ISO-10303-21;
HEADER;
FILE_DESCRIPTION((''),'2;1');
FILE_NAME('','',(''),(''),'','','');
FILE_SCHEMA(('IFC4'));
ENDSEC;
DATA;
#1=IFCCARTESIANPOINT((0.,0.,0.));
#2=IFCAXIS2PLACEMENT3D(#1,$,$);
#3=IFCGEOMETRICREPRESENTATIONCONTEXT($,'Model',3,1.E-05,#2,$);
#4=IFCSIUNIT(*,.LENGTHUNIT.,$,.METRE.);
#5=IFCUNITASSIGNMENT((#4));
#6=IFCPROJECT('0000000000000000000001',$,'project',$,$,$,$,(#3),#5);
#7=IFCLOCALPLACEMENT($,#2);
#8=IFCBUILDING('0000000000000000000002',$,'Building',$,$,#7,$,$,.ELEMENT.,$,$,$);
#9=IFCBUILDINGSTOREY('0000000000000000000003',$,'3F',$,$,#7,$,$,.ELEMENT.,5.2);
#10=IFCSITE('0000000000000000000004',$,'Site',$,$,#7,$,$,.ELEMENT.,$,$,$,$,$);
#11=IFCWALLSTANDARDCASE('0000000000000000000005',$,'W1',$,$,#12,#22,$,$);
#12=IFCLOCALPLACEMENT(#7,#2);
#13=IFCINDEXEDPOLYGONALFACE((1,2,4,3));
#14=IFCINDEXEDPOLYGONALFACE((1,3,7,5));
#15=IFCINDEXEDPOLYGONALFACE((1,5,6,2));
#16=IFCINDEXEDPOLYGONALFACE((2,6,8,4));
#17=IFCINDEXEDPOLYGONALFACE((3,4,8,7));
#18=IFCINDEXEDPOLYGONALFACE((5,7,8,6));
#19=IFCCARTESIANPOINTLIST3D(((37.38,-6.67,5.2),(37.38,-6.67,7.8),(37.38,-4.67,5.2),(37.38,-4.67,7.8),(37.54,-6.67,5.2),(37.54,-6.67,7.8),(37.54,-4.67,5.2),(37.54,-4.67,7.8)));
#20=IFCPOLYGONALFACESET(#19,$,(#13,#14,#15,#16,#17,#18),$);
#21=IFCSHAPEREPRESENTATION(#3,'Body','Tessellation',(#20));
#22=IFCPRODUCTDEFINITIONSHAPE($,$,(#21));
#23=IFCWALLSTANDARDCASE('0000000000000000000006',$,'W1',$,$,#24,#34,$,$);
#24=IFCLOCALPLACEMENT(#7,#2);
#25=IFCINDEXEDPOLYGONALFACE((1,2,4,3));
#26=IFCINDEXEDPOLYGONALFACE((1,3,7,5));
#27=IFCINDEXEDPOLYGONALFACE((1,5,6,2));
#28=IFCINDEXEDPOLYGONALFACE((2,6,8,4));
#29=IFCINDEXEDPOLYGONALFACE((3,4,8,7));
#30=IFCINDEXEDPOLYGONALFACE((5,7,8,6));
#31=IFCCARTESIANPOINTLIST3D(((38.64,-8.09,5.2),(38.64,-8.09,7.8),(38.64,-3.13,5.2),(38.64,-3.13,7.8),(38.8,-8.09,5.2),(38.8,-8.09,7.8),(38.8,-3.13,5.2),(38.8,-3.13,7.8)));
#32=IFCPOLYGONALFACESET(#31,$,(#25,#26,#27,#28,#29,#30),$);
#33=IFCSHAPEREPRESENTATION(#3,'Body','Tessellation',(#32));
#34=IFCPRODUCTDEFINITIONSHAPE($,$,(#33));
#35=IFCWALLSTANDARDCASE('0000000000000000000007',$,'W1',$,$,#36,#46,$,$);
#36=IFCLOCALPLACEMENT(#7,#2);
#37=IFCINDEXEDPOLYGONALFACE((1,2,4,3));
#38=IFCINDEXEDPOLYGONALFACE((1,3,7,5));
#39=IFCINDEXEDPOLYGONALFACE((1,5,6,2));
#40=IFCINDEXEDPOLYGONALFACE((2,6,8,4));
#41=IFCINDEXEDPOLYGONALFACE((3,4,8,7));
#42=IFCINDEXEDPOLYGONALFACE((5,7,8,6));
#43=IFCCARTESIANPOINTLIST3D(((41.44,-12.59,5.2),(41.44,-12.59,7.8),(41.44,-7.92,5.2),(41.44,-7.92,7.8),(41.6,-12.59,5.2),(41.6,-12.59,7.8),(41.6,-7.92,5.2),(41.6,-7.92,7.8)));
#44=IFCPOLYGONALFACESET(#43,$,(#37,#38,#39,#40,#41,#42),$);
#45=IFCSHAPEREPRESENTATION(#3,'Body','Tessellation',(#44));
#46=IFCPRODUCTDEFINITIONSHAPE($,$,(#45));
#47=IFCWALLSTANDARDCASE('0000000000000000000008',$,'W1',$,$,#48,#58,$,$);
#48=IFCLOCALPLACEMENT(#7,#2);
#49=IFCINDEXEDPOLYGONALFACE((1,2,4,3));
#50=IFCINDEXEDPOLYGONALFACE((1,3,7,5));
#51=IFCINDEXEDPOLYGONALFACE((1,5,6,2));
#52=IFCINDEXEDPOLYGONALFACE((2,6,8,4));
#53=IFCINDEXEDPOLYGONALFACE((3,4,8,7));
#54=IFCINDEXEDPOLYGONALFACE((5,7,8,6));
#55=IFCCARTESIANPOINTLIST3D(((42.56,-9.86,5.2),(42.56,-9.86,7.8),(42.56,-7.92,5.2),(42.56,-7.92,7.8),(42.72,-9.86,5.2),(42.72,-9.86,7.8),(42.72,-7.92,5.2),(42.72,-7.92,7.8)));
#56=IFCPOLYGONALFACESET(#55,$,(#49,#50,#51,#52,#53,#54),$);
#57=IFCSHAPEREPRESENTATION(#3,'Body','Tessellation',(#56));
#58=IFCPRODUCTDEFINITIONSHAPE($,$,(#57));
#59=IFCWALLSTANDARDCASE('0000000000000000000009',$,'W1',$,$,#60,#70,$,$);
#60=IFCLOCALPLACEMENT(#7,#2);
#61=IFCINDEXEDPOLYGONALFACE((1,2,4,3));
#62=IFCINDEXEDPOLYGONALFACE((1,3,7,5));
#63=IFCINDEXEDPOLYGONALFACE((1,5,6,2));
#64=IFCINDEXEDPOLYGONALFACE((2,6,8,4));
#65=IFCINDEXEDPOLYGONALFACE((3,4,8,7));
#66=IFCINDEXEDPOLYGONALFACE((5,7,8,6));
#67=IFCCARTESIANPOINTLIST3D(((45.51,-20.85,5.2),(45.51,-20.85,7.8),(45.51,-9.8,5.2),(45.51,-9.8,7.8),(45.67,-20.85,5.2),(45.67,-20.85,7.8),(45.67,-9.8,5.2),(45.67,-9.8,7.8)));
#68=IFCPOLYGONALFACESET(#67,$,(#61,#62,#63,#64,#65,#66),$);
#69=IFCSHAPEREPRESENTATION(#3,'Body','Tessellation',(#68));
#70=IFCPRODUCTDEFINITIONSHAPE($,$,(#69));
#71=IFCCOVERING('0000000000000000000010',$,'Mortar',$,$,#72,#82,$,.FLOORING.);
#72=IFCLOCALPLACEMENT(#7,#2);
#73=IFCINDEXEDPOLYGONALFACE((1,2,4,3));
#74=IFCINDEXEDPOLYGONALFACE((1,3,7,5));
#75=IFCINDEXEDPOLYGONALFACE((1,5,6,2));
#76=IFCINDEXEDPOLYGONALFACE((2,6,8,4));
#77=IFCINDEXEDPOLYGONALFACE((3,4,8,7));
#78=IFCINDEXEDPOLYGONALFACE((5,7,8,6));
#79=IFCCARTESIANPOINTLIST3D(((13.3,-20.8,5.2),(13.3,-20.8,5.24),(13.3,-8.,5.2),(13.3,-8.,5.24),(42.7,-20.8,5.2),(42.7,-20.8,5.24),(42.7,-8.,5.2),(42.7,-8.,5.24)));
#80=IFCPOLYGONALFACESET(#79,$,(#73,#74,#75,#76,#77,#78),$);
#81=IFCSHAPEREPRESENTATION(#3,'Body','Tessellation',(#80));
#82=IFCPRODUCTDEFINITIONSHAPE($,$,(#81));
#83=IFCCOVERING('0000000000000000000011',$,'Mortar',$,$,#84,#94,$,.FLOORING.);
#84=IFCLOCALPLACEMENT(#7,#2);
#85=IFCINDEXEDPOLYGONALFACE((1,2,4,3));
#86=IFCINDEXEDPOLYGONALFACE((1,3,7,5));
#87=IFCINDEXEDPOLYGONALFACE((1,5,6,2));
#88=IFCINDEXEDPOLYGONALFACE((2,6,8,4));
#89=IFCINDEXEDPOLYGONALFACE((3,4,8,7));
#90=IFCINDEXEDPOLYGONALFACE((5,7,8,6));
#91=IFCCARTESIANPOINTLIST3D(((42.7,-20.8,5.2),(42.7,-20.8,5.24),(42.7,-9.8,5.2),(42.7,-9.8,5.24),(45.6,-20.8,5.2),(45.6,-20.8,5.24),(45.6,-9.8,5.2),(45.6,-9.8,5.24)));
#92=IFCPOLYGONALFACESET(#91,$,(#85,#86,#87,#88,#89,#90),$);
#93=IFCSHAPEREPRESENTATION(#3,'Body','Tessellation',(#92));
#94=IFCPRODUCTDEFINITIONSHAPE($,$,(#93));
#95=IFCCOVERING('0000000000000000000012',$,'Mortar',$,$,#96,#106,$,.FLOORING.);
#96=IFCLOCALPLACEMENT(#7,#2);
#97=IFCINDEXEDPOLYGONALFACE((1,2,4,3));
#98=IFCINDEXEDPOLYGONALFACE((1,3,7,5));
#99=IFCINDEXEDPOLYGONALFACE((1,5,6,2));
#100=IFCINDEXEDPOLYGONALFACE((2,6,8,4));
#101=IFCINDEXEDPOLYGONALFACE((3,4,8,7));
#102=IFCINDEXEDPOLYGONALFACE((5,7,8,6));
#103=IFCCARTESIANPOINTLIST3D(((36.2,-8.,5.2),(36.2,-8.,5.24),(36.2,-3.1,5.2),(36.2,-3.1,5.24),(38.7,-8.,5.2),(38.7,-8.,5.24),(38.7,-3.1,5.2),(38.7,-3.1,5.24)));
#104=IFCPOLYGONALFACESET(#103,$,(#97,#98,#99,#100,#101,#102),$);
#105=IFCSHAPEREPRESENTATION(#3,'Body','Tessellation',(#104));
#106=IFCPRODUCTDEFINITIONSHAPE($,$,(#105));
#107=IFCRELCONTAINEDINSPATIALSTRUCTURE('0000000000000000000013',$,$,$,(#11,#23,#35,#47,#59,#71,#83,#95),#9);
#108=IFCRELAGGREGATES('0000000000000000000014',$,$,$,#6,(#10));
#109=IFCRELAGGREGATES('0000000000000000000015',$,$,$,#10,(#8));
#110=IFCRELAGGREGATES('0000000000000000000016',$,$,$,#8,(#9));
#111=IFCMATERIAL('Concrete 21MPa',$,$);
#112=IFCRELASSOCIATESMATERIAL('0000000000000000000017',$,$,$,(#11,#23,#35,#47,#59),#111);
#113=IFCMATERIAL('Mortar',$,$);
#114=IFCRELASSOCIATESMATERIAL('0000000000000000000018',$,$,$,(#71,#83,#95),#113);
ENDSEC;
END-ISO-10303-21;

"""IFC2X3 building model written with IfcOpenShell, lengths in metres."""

from ifc_helpers import new_model, si_unit, frame, origin, origin_2d, place, context, project, spatial, rectangle, extrude, material, element, save


model = new_model("IFC2X3")

# Units and contexts
model_context = context("Model", 3, precision=1e-05, world=origin())
ifc_project = project(units=[si_unit("LENGTHUNIT", "METRE")], contexts=[model_context])

# Site, building, storey
placement = place(None, origin())
site = spatial("IfcSite", under=ifc_project, at=placement, Name="Site", CompositionType="ELEMENT")
building = spatial("IfcBuilding", under=site, at=placement, Name="Building", CompositionType="ELEMENT")
storey = spatial("IfcBuildingStorey", under=building, at=placement, Name="3F", CompositionType="ELEMENT", Elevation=5.2)

# Shared definitions
ifc_material_1 = material(Name="Concrete 21MPa")

# Walls
wall_1_placement = place(None, frame((37.46, -5.67, 5.2)))
element("IfcWallStandardCase", 1, at=wall_1_placement, inside=storey, material=ifc_material_1, Name="W1", context=model_context, shape_type="SweptSolid", body=[
    extrude(rectangle(XDim=0.16, YDim=2.0, at=origin_2d()), origin(), (0.0, 0.0, 1.0), 2.6),
])
wall_2_placement = place(None, frame((38.72, -5.61, 5.2)))
element("IfcWallStandardCase", 2, at=wall_2_placement, inside=storey, material=ifc_material_1, Name="W1", context=model_context, shape_type="SweptSolid", body=[
    extrude(rectangle(XDim=0.16, YDim=4.96, at=origin_2d()), origin(), (0.0, 0.0, 1.0), 2.6),
])
wall_3_placement = place(None, frame((41.52, -10.255, 5.2)))
element("IfcWallStandardCase", 3, at=wall_3_placement, inside=storey, material=ifc_material_1, Name="W1", context=model_context, shape_type="SweptSolid", body=[
    extrude(rectangle(XDim=0.16, YDim=4.67, at=origin_2d()), origin(), (0.0, 0.0, 1.0), 2.6),
])
wall_4_placement = place(None, frame((42.64, -8.89, 5.2)))
element("IfcWallStandardCase", 4, at=wall_4_placement, inside=storey, material=ifc_material_1, Name="W1", context=model_context, shape_type="SweptSolid", body=[
    extrude(rectangle(XDim=0.16, YDim=1.94, at=origin_2d()), origin(), (0.0, 0.0, 1.0), 2.6),
])
wall_5_placement = place(None, frame((45.59, -15.325, 5.2)))
element("IfcWallStandardCase", 5, at=wall_5_placement, inside=storey, material=ifc_material_1, Name="W1", context=model_context, shape_type="SweptSolid", body=[
    extrude(rectangle(XDim=0.16, YDim=11.05, at=origin_2d()), origin(), (0.0, 0.0, 1.0), 2.6),
])

# Coverings
ifc_material_2 = material(Name="Mortar")
covering_1_placement = place(None, frame((28.0, -14.4, 5.2)))
element("IfcCovering", 6, at=covering_1_placement, inside=storey, material=ifc_material_2, Name="Mortar", PredefinedType="FLOORING", context=model_context, shape_type="SweptSolid", body=[
    extrude(rectangle(XDim=29.4, YDim=12.8, at=origin_2d()), origin(), (0.0, 0.0, 1.0), 0.04),
])
covering_2_placement = place(None, frame((44.15, -15.3, 5.2)))
element("IfcCovering", 7, at=covering_2_placement, inside=storey, material=ifc_material_2, Name="Mortar", PredefinedType="FLOORING", context=model_context, shape_type="SweptSolid", body=[
    extrude(rectangle(XDim=2.9, YDim=11.0, at=origin_2d()), origin(), (0.0, 0.0, 1.0), 0.04),
])
covering_3_placement = place(None, frame((37.45, -5.55, 5.2)))
element("IfcCovering", 8, at=covering_3_placement, inside=storey, material=ifc_material_2, Name="Mortar", PredefinedType="FLOORING", context=model_context, shape_type="SweptSolid", body=[
    extrude(rectangle(XDim=2.5, YDim=4.9, at=origin_2d()), origin(), (0.0, 0.0, 1.0), 0.04),
])

save(model, "model.ifc")
